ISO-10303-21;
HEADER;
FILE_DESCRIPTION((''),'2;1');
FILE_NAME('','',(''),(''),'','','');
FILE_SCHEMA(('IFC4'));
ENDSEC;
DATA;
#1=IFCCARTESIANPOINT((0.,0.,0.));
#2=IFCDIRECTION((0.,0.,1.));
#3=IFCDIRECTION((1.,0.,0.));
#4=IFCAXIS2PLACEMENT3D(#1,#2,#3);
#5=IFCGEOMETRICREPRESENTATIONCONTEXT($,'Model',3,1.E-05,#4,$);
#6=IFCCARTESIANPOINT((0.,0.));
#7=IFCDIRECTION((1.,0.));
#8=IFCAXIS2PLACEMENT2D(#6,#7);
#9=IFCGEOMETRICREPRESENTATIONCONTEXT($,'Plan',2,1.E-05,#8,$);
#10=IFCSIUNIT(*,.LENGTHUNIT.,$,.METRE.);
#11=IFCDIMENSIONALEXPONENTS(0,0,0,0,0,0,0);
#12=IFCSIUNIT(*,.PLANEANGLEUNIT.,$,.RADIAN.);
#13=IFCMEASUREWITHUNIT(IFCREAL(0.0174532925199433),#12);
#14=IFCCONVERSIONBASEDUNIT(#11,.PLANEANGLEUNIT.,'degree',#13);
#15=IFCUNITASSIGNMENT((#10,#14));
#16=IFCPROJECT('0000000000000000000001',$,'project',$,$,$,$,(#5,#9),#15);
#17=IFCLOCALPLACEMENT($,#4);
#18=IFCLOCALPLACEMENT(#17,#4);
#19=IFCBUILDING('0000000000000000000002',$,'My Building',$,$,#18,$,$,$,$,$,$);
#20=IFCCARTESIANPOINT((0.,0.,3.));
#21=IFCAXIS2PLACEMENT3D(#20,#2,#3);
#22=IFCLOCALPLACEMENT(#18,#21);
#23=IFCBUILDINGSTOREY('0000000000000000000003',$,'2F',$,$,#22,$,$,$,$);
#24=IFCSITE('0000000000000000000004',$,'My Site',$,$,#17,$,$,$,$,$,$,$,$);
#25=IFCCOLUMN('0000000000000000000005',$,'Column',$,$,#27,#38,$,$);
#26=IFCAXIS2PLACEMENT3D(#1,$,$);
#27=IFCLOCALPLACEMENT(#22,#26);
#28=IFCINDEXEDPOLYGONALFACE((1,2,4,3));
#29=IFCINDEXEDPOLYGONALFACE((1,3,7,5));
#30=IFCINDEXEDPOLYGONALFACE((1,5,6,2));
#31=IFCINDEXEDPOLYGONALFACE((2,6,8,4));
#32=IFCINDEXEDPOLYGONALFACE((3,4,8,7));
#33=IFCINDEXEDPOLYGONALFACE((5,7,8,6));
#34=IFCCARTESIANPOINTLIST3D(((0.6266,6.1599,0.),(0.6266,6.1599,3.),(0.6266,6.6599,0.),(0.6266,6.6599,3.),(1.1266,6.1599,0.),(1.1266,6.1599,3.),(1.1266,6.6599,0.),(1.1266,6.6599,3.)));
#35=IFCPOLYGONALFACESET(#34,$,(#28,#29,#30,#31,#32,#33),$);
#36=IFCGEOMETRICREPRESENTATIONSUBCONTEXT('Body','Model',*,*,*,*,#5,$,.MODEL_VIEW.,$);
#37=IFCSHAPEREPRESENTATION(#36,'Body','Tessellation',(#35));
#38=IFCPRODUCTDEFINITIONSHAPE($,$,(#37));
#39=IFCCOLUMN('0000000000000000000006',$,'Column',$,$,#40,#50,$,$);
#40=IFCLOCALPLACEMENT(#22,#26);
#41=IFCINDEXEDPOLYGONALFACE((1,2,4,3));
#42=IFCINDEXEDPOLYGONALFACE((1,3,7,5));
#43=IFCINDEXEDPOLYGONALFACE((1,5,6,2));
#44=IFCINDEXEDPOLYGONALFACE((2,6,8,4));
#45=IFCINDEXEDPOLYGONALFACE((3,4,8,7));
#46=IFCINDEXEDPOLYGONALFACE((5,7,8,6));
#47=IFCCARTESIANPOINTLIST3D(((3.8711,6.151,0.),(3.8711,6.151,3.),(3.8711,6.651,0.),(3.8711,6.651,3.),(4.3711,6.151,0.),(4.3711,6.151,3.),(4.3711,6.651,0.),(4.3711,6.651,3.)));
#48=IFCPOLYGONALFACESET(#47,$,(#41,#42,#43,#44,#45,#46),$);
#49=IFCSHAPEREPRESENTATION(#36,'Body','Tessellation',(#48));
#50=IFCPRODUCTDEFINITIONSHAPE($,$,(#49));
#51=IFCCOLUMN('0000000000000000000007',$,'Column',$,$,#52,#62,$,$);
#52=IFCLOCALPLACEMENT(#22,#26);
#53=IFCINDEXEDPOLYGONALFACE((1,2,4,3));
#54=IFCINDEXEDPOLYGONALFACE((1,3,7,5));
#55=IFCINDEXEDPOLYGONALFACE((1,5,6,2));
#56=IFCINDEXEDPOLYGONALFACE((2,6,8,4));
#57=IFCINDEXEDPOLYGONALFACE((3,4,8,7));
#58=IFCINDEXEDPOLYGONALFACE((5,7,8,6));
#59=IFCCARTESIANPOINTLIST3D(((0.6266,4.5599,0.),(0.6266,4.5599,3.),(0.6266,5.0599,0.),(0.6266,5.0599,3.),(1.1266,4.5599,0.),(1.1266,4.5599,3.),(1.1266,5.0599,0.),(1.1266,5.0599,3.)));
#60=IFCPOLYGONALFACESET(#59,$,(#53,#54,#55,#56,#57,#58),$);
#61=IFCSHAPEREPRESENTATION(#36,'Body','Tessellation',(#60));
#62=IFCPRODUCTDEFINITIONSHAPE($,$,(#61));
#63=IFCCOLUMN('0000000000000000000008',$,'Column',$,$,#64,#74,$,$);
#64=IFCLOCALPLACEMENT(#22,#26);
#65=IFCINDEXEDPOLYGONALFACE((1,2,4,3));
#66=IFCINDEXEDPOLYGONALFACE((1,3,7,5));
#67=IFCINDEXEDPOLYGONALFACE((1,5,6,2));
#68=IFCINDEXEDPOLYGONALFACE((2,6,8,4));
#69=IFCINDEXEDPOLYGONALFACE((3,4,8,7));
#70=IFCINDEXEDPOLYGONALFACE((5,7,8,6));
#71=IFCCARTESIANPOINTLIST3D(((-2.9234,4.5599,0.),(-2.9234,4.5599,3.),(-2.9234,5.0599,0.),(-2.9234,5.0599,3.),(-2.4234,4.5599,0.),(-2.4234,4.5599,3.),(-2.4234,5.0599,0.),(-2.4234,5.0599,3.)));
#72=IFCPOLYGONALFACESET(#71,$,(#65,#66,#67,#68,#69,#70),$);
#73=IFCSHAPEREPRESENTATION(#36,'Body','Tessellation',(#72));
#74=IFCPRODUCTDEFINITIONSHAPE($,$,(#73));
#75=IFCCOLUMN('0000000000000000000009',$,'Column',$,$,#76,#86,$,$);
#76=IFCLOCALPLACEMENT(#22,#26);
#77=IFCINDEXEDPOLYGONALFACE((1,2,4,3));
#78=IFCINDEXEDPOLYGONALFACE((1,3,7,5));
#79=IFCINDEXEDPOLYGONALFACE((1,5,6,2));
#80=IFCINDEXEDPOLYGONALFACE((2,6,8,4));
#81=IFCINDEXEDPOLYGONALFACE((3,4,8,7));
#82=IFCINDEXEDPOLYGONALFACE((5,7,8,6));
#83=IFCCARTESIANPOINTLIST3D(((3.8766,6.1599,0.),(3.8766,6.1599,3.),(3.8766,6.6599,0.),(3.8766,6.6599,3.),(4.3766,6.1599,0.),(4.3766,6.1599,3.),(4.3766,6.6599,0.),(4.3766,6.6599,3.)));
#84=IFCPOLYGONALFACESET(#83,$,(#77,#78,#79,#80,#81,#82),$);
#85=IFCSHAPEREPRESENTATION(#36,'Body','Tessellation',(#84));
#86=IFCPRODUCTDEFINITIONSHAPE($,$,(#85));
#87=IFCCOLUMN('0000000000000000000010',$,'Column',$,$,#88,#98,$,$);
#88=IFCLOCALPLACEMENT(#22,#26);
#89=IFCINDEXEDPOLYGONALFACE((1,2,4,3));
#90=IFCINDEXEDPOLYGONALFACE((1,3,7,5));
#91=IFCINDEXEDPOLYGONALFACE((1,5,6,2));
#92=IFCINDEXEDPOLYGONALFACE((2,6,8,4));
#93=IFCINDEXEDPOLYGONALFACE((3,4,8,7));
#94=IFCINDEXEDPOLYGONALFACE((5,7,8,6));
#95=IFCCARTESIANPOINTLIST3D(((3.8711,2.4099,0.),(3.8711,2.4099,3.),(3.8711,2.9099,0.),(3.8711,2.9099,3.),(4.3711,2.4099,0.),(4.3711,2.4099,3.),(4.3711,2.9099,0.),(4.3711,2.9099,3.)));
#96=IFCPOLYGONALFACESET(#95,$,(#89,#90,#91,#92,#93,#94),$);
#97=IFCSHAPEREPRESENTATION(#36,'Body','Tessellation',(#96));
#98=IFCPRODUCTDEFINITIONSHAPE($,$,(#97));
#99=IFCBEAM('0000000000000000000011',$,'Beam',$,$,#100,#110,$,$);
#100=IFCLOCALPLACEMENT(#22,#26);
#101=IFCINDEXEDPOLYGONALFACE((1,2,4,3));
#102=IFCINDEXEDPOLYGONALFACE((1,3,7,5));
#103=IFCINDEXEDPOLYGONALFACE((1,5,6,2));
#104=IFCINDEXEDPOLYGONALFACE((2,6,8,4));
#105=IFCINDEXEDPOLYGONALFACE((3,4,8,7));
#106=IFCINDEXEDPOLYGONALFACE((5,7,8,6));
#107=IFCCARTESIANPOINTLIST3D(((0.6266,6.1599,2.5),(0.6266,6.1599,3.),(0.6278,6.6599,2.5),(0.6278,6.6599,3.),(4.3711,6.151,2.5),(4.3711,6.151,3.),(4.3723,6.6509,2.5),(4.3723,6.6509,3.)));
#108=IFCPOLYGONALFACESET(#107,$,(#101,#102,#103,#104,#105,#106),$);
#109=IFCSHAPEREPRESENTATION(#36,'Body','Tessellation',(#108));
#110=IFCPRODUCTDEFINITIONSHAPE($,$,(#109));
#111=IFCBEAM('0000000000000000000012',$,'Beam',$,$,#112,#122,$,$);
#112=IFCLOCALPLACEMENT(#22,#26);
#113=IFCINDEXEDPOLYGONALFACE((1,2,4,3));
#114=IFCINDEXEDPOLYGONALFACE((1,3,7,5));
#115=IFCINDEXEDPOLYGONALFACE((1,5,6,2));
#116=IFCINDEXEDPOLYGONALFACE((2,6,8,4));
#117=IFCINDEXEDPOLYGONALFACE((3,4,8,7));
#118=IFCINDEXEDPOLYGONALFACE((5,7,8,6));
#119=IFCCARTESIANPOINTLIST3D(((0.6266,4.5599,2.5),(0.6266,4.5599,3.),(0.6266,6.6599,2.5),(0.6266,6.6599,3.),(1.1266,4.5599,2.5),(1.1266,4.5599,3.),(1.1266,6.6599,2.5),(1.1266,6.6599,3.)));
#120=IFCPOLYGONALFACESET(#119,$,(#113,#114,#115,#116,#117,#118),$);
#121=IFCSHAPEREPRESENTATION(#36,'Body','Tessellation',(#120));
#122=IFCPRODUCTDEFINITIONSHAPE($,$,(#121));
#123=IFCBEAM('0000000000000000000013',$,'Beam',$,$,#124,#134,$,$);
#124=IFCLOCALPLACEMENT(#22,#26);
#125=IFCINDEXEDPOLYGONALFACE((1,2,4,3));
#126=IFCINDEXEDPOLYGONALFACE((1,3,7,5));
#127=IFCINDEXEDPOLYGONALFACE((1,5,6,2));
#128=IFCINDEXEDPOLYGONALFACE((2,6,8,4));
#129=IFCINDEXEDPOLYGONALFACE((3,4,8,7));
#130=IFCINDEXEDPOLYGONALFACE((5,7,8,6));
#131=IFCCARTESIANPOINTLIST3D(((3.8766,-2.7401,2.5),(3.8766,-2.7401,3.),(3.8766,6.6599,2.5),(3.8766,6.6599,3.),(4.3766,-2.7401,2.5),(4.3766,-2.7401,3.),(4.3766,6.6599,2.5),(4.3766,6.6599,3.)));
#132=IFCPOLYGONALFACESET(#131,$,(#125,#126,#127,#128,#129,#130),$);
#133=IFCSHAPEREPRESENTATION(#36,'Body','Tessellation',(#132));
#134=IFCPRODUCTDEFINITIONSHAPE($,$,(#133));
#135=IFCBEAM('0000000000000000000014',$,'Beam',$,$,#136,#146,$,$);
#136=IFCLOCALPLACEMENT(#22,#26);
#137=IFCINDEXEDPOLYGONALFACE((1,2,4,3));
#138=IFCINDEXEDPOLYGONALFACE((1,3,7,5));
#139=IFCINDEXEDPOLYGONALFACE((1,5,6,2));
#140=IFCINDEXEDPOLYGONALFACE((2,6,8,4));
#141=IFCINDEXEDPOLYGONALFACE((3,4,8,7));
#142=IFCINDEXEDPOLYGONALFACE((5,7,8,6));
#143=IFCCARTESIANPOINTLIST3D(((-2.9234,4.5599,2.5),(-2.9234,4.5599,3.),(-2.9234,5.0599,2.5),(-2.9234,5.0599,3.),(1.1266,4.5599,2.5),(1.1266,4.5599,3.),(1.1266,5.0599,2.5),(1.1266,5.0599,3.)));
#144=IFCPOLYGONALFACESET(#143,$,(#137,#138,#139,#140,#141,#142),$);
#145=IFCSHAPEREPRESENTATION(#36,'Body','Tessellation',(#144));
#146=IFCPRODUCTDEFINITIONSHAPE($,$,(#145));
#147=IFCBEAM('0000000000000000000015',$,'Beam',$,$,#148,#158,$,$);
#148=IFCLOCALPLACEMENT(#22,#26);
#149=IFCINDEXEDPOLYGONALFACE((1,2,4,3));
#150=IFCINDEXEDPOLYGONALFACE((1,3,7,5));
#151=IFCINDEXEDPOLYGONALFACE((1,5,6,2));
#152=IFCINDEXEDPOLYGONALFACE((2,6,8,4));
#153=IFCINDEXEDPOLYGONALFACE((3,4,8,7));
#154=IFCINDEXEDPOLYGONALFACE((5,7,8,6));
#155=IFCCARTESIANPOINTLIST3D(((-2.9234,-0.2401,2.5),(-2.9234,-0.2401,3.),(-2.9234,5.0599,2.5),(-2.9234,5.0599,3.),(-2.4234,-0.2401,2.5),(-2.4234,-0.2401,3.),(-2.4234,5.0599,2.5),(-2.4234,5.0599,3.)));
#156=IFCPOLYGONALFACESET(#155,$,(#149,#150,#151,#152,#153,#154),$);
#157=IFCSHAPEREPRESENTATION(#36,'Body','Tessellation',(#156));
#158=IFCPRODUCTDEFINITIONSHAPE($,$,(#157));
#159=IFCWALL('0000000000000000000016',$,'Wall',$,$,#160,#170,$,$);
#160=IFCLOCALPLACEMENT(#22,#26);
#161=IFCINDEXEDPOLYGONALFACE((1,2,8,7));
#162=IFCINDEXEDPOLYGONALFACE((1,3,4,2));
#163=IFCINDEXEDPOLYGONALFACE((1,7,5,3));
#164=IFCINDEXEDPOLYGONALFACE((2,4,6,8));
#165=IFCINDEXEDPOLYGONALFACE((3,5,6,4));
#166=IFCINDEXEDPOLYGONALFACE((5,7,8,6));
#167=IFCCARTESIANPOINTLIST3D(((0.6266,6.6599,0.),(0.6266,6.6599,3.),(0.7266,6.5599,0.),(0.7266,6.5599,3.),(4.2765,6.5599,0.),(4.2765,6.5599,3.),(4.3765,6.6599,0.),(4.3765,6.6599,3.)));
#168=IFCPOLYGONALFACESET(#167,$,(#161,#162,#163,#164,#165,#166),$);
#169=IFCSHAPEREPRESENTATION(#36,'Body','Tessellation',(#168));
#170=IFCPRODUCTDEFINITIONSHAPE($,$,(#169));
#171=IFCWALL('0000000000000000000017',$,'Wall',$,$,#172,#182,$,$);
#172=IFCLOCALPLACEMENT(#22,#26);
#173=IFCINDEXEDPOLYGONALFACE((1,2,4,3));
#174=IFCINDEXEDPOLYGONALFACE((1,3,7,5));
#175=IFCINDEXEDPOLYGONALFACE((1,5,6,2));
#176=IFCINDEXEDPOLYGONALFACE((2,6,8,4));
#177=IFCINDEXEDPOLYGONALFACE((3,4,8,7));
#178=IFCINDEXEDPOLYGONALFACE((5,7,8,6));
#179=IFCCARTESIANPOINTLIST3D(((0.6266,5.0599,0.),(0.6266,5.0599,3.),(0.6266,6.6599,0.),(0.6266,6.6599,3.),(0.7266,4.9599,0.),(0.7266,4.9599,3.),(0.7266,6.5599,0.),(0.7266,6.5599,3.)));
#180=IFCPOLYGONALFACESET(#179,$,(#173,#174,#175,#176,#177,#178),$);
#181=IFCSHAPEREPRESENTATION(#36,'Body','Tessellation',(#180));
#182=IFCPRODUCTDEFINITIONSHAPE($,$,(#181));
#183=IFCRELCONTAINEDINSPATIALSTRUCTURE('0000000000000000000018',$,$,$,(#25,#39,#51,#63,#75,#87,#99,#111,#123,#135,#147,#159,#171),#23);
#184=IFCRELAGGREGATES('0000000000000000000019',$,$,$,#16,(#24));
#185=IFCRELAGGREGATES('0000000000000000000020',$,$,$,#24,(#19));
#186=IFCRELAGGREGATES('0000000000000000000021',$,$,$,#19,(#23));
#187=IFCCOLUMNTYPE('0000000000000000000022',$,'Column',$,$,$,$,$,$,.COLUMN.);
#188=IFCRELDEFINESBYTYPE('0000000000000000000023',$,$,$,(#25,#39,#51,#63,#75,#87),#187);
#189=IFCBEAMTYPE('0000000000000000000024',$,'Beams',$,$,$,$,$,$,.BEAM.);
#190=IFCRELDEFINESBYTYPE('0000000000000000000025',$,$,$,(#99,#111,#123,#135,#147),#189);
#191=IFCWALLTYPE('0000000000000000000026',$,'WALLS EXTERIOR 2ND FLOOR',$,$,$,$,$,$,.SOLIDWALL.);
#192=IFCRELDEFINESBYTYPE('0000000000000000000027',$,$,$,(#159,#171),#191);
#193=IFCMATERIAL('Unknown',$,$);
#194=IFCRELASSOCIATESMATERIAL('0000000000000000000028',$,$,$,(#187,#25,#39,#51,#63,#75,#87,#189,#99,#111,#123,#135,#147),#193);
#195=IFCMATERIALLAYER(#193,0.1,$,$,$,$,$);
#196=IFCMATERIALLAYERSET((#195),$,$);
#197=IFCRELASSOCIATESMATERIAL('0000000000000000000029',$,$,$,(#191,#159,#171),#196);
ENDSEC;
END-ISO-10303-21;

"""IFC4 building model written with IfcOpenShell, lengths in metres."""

from ifc_helpers import new_model, entity, si_unit, converted_unit, frame, origin_with_axes, origin_2d_with_axis, place, context, subcontext, project, spatial, line, indexed_curve, rectangle, outline, extrude, material, layer, layer_set, layer_usage, material_profile, profile_set, profile_usage, type_object, element, save


model = new_model("IFC4")

# Units and contexts
model_context = context("Model", 3, precision=1e-05, world=origin_with_axes())
plan_context = context("Plan", 2, precision=1e-05, world=origin_2d_with_axis())
body_context_1 = subcontext(model_context, "Body", "Model", "MODEL_VIEW")
ifc_project = project(units=[si_unit("LENGTHUNIT", "METRE"), converted_unit("PLANEANGLEUNIT", "degree", entity("IfcReal", 0.0174532925199433), si_unit("PLANEANGLEUNIT", "RADIAN"), dimensions=[0, 0, 0, 0, 0, 0, 0])], contexts=[model_context, plan_context])

# Site, building, storey
site_placement = place(None, origin_with_axes())
site = spatial("IfcSite", under=ifc_project, at=site_placement, Name="My Site")
building_placement = place(site_placement, origin_with_axes())
building = spatial("IfcBuilding", under=site, at=building_placement, Name="My Building")
storey_placement = place(building_placement, frame((0.0, 0.0, 3.0), z_axis=(0.0, 0.0, 1.0), x_axis=(1.0, 0.0, 0.0)))
storey = spatial("IfcBuildingStorey", under=building, at=storey_placement, Name="2F")

# Columns
ifc_material = material(Name="Unknown")
ifc_material_profile_1 = material_profile(ifc_material, rectangle(XDim=0.5, YDim=0.5))
ifc_profile_set_1 = profile_set([ifc_material_profile_1])
ifc_profile_usage_1 = profile_usage(ifc_profile_set_1, cardinal=5)
column_type = type_object("IfcColumnType", Name="Column", PredefinedType="COLUMN", material=ifc_profile_set_1)
column_1_placement = place(storey_placement, frame((0.8766, 6.4099, 0.0), z_axis=(0.0, 0.0, 1.0), x_axis=(1.0, 0.0, 0.0)))
element("IfcColumn", 1, at=column_1_placement, inside=storey, type_object=column_type, material=ifc_profile_usage_1, Name="Column", context=body_context_1, shape_type="SweptSolid", body=[
    extrude(rectangle(XDim=0.5, YDim=0.5), origin_with_axes(), (0.0, 0.0, 1.0), 3.0),
])
ifc_profile_usage_2 = profile_usage(ifc_profile_set_1, cardinal=5)
column_2_placement = place(storey_placement, frame((4.1211, 6.401, 0.0), z_axis=(0.0, 0.0, 1.0), x_axis=(1.0, 0.0, 0.0)))
element("IfcColumn", 2, at=column_2_placement, inside=storey, type_object=column_type, material=ifc_profile_usage_2, Name="Column", context=body_context_1, shape_type="SweptSolid", body=[
    extrude(rectangle(XDim=0.5, YDim=0.5), origin_with_axes(), (0.0, 0.0, 1.0), 3.0),
])
ifc_profile_usage_3 = profile_usage(ifc_profile_set_1, cardinal=5)
column_3_placement = place(storey_placement, frame((0.8766, 4.8099, 0.0), z_axis=(0.0, 0.0, 1.0), x_axis=(1.0, 0.0, 0.0)))
element("IfcColumn", 3, at=column_3_placement, inside=storey, type_object=column_type, material=ifc_profile_usage_3, Name="Column", context=body_context_1, shape_type="SweptSolid", body=[
    extrude(rectangle(XDim=0.5, YDim=0.5), origin_with_axes(), (0.0, 0.0, 1.0), 3.0),
])
ifc_profile_usage_4 = profile_usage(ifc_profile_set_1, cardinal=5)
column_4_placement = place(storey_placement, frame((-2.6734, 4.8099, 0.0), z_axis=(0.0, 0.0, 1.0), x_axis=(1.0, 0.0, 0.0)))
element("IfcColumn", 4, at=column_4_placement, inside=storey, type_object=column_type, material=ifc_profile_usage_4, Name="Column", context=body_context_1, shape_type="SweptSolid", body=[
    extrude(rectangle(XDim=0.5, YDim=0.5), origin_with_axes(), (0.0, 0.0, 1.0), 3.0),
])
ifc_profile_usage_5 = profile_usage(ifc_profile_set_1, cardinal=5)
column_5_placement = place(storey_placement, frame((4.1266, 6.4099, 0.0), z_axis=(0.0, 0.0, 1.0), x_axis=(1.0, 0.0, 0.0)))
element("IfcColumn", 5, at=column_5_placement, inside=storey, type_object=column_type, material=ifc_profile_usage_5, Name="Column", context=body_context_1, shape_type="SweptSolid", body=[
    extrude(rectangle(XDim=0.5, YDim=0.5), origin_with_axes(), (0.0, 0.0, 1.0), 3.0),
])
ifc_profile_usage_6 = profile_usage(ifc_profile_set_1, cardinal=5)
column_6_placement = place(storey_placement, frame((4.1211, 2.6599, 0.0), z_axis=(0.0, 0.0, 1.0), x_axis=(1.0, 0.0, 0.0)))
element("IfcColumn", 6, at=column_6_placement, inside=storey, type_object=column_type, material=ifc_profile_usage_6, Name="Column", context=body_context_1, shape_type="SweptSolid", body=[
    extrude(rectangle(XDim=0.5, YDim=0.5), origin_with_axes(), (0.0, 0.0, 1.0), 3.0),
])

# Beams
ifc_material_profile_2 = material_profile(ifc_material, rectangle(XDim=0.5, YDim=0.5))
ifc_profile_set_2 = profile_set([ifc_material_profile_2])
ifc_profile_usage_7 = profile_usage(ifc_profile_set_2, cardinal=7)
beam_type = type_object("IfcBeamType", Name="Beams", PredefinedType="BEAM", material=ifc_profile_set_2)
beam_1_placement = place(storey_placement, frame((4.3711, 6.151, 3.0), z_axis=(-0.999997, 0.002388, 0.0), x_axis=(-0.002388, -0.999997, 0.0)))
element("IfcBeam", 7, at=beam_1_placement, inside=storey, type_object=beam_type, material=ifc_profile_usage_7, Name="Beam", context=body_context_1, shape_type="SweptSolid", body=[
    extrude(rectangle(XDim=0.5, YDim=0.5), frame((-0.25, -0.25, 0.0), z_axis=(0.0, 0.0, 1.0), x_axis=(1.0, 0.0, 0.0)), (0.0, 0.0, 1.0), 3.7445),
])
ifc_profile_usage_8 = profile_usage(ifc_profile_set_2, cardinal=7)
beam_2_placement = place(storey_placement, frame((1.1266, 6.6599, 3.0), z_axis=(0.0, -1.0, 0.0), x_axis=(1.0, 0.0, 0.0)))
element("IfcBeam", 8, at=beam_2_placement, inside=storey, type_object=beam_type, material=ifc_profile_usage_8, Name="Beam", context=body_context_1, shape_type="SweptSolid", body=[
    extrude(rectangle(XDim=0.5, YDim=0.5), frame((-0.25, -0.25, 0.0), z_axis=(0.0, 0.0, 1.0), x_axis=(1.0, 0.0, 0.0)), (0.0, 0.0, 1.0), 2.1),
])
ifc_profile_usage_9 = profile_usage(ifc_profile_set_2, cardinal=7)
beam_3_placement = place(storey_placement, frame((4.3766, 6.6599, 3.0), z_axis=(0.0, -1.0, 0.0), x_axis=(1.0, 0.0, 0.0)))
element("IfcBeam", 9, at=beam_3_placement, inside=storey, type_object=beam_type, material=ifc_profile_usage_9, Name="Beam", context=body_context_1, shape_type="SweptSolid", body=[
    extrude(rectangle(XDim=0.5, YDim=0.5), frame((-0.25, -0.25, 0.0), z_axis=(0.0, 0.0, 1.0), x_axis=(1.0, 0.0, 0.0)), (0.0, 0.0, 1.0), 9.4),
])
ifc_profile_usage_10 = profile_usage(ifc_profile_set_2, cardinal=7)
beam_4_placement = place(storey_placement, frame((1.1266, 4.5599, 3.0), z_axis=(-1.0, -0.00001, 0.0), x_axis=(0.00001, -1.0, 0.0)))
element("IfcBeam", 10, at=beam_4_placement, inside=storey, type_object=beam_type, material=ifc_profile_usage_10, Name="Beam", context=body_context_1, shape_type="SweptSolid", body=[
    extrude(rectangle(XDim=0.5, YDim=0.5), frame((-0.25, -0.25, 0.0), z_axis=(0.0, 0.0, 1.0), x_axis=(1.0, 0.0, 0.0)), (0.0, 0.0, 1.0), 4.05),
])
ifc_profile_usage_11 = profile_usage(ifc_profile_set_2, cardinal=7)
beam_5_placement = place(storey_placement, frame((-2.4234, 5.0599, 3.0), z_axis=(0.000001, -1.0, 0.0), x_axis=(1.0, 0.000001, 0.0)))
element("IfcBeam", 11, at=beam_5_placement, inside=storey, type_object=beam_type, material=ifc_profile_usage_11, Name="Beam", context=body_context_1, shape_type="SweptSolid", body=[
    extrude(rectangle(XDim=0.5, YDim=0.5), frame((-0.25, -0.25, 0.0), z_axis=(0.0, 0.0, 1.0), x_axis=(1.0, 0.0, 0.0)), (0.0, 0.0, 1.0), 5.3),
])

# Shared definitions
ifc_layer_1 = layer(ifc_material, 0.1)
ifc_layer_set_1 = layer_set([ifc_layer_1])
wall_type_1 = type_object("IfcWallType", Name="WALLS EXTERIOR 2ND FLOOR", PredefinedType="SOLIDWALL", material=ifc_layer_set_1)

# Walls
ifc_layer_usage_1 = layer_usage(ifc_layer_set_1, "AXIS2", "POSITIVE", 0.0)
wall_1_placement = place(storey_placement, frame((4.3765, 6.6599, 0.0), z_axis=(0.0, 0.0, 1.0), x_axis=(-1.0, 0.0, 0.0)))
element("IfcWall", 12, at=wall_1_placement, inside=storey, type_object=wall_type_1, material=ifc_layer_usage_1, Name="Wall", context=body_context_1, shape_type="SweptSolid", body=[
    extrude(outline(indexed_curve([(0.0, 0.0), (0.1, 0.1), (3.6499, 0.1), (3.7499, 0.0)], segments=[line(1, 2, 3, 4, 1)])), origin_with_axes(), (0.0, 0.0, 1.0), 3.0),
])
ifc_layer_usage_2 = layer_usage(ifc_layer_set_1, "AXIS2", "POSITIVE", 0.0)
wall_2_placement = place(storey_placement, frame((0.6266, 6.6599, 0.0), z_axis=(0.0, 0.0, 1.0), x_axis=(0.0, -1.0, 0.0)))
element("IfcWall", 13, at=wall_2_placement, inside=storey, type_object=wall_type_1, material=ifc_layer_usage_2, Name="Wall", context=body_context_1, shape_type="SweptSolid", body=[
    extrude(outline(indexed_curve([(0.0, 0.0), (0.1, 0.1), (1.7, 0.1), (1.6, 0.0)], segments=[line(1, 2, 3, 4, 1)])), origin_with_axes(), (0.0, 0.0, 1.0), 3.0),
])

save(model, "model.ifc")
